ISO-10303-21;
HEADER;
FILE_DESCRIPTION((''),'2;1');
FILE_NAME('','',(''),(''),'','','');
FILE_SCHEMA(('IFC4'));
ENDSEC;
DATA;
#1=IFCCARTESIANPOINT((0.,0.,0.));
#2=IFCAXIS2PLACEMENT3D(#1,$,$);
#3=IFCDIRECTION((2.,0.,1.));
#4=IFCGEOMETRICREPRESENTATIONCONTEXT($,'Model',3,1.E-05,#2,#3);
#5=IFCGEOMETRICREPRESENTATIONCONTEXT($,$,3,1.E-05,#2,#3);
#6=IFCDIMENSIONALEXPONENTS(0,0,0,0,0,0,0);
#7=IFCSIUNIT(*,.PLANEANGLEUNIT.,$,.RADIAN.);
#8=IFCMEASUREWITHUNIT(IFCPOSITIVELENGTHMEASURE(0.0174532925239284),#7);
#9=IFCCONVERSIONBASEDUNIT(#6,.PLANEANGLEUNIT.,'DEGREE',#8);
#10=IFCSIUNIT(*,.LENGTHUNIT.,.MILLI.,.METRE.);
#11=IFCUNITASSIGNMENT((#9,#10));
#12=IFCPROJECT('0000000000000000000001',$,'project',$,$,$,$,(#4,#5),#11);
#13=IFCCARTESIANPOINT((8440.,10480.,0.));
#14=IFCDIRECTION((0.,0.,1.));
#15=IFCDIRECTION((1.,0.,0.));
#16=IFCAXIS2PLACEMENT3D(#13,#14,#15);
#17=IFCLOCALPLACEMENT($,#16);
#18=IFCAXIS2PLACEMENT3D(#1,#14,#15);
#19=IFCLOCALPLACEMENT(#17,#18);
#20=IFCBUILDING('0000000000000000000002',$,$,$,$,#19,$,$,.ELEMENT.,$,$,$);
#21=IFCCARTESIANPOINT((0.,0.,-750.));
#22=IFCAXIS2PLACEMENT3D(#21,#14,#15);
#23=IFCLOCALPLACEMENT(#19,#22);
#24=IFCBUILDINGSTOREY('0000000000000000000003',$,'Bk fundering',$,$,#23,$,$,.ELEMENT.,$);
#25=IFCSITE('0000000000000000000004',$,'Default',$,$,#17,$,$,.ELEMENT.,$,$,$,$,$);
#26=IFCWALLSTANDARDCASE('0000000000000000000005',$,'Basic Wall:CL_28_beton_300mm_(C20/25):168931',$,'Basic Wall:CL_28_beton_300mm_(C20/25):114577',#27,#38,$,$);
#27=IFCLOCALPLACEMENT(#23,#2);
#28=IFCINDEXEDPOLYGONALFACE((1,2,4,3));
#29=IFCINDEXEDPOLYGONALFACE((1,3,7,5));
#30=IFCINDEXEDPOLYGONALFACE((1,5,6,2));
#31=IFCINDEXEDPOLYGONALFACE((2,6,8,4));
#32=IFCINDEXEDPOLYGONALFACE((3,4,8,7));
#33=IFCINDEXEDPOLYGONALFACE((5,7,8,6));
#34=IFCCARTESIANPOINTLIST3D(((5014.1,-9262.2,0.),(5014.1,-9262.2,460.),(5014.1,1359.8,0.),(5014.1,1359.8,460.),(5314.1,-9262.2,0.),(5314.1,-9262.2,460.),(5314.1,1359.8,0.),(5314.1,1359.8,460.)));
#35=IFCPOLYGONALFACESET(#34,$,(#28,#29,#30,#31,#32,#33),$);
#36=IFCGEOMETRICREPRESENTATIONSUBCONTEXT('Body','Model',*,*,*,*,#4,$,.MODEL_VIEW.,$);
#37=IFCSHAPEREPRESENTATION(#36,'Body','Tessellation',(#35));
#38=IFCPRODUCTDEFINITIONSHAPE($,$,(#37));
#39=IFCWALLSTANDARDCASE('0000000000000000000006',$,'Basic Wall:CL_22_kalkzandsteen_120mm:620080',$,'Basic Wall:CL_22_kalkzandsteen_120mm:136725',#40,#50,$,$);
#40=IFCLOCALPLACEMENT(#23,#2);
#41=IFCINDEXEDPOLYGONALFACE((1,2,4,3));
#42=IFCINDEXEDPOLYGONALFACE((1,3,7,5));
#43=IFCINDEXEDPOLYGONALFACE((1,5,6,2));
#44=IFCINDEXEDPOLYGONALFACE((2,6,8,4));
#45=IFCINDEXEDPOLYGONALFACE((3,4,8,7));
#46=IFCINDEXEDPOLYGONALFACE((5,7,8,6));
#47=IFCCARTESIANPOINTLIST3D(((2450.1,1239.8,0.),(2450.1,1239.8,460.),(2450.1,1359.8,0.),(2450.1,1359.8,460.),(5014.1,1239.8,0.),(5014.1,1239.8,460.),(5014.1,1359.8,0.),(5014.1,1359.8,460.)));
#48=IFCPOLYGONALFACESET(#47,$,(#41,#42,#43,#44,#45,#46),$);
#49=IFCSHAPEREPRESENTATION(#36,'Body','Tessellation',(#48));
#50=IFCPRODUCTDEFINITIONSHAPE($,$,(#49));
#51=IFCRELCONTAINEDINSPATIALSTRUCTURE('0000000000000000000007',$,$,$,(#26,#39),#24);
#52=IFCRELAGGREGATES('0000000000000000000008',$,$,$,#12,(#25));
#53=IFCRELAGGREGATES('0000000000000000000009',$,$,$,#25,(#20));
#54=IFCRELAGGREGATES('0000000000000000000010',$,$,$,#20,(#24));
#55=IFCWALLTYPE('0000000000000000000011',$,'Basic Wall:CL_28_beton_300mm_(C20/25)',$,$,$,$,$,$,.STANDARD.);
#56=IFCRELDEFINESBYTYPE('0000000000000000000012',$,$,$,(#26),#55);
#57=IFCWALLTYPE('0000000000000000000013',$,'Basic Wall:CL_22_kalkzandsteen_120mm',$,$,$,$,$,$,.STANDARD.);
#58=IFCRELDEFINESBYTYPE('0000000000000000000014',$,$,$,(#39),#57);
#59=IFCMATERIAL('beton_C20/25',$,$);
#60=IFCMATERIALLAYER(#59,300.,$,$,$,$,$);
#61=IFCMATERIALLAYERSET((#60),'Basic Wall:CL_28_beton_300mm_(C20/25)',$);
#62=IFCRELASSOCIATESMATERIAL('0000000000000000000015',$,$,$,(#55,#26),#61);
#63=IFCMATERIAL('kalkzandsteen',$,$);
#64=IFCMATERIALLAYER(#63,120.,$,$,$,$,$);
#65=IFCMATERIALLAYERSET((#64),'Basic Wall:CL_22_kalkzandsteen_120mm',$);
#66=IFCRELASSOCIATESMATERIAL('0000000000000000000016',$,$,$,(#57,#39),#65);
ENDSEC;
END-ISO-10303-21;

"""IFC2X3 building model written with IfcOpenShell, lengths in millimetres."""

from ifc_helpers import new_model, entity, si_unit, converted_unit, direction, frame, frame_2d, origin, origin_with_axes, place, context, subcontext, project, spatial, rectangle, extrude, material, layer, layer_set, layer_usage, type_object, element, save


model = new_model("IFC2X3")

# Units and contexts
model_context = context("Model", 3, precision=1e-05, world=origin(), true_north=direction((2.0, 0.0, 1.0)))
context_of_model = context(None, 3, precision=1e-05, world=origin(), true_north=direction((2.0, 0.0, 1.0)))
body_context = subcontext(model_context, "Body", "Model", "MODEL_VIEW")
ifc_project = project(units=[converted_unit("PLANEANGLEUNIT", "DEGREE", entity("IfcPositiveLengthMeasure", 0.0174532925239284), si_unit("PLANEANGLEUNIT", "RADIAN"), dimensions=[0, 0, 0, 0, 0, 0, 0]), si_unit("LENGTHUNIT", "METRE", prefix="MILLI")], contexts=[model_context, context_of_model])

# Site, building, storey
site_placement = place(None, frame((8440.0, 10480.0, 0.0), z_axis=(0.0, 0.0, 1.0), x_axis=(1.0, 0.0, 0.0)))
site = spatial("IfcSite", under=ifc_project, at=site_placement, Name="Default", CompositionType="ELEMENT")
building_placement = place(site_placement, origin_with_axes())
building = spatial("IfcBuilding", under=site, at=building_placement, CompositionType="ELEMENT")
storey_placement = place(building_placement, frame((0.0, 0.0, -750.0), z_axis=(0.0, 0.0, 1.0), x_axis=(1.0, 0.0, 0.0)))
storey = spatial("IfcBuildingStorey", under=building, at=storey_placement, Name="Bk fundering", CompositionType="ELEMENT")

# Shared definitions
ifc_material_1 = material(Name="beton_C20/25")

# Shared definitions
ifc_material_2 = material(Name="kalkzandsteen")

# Walls
ifc_layer_1 = layer(ifc_material_1, 300.0)
ifc_layer_set_1 = layer_set([ifc_layer_1], Name="Basic Wall:CL_28_beton_300mm_(C20/25)")
ifc_layer_usage_1 = layer_usage(ifc_layer_set_1, "AXIS2", "NEGATIVE", 150.0)
wall_type_1 = type_object("IfcWallType", Name="Basic Wall:CL_28_beton_300mm_(C20/25)", PredefinedType="STANDARD", material=ifc_layer_set_1)
wall_1_placement = place(storey_placement, frame((5164.1, 1359.8, 0.0), z_axis=(0.0, 0.0, 1.0), x_axis=(0.0, -1.0, 0.0)))
element("IfcWallStandardCase", 1, at=wall_1_placement, inside=storey, type_object=wall_type_1, material=ifc_layer_usage_1, Name="Basic Wall:CL_28_beton_300mm_(C20/25):168931", ObjectType="Basic Wall:CL_28_beton_300mm_(C20/25):114577", context=body_context, shape_type="SweptSolid", body=[
    extrude(rectangle(XDim=10622.0, YDim=300.0, at=frame_2d((5311.0, 0.0), x_axis=(-1.0, 0.0))), origin(), (0.0, 0.0, 1.0), 460.0),
])
ifc_layer_2 = layer(ifc_material_2, 120.0)
ifc_layer_set_2 = layer_set([ifc_layer_2], Name="Basic Wall:CL_22_kalkzandsteen_120mm")
ifc_layer_usage_2 = layer_usage(ifc_layer_set_2, "AXIS2", "NEGATIVE", 60.0)
wall_type_2 = type_object("IfcWallType", Name="Basic Wall:CL_22_kalkzandsteen_120mm", PredefinedType="STANDARD", material=ifc_layer_set_2)
wall_2_placement = place(storey_placement, frame((5014.1, 1299.8, 0.0), z_axis=(0.0, 0.0, 1.0), x_axis=(-1.0, 0.0, 0.0)))
element("IfcWallStandardCase", 2, at=wall_2_placement, inside=storey, type_object=wall_type_2, material=ifc_layer_usage_2, Name="Basic Wall:CL_22_kalkzandsteen_120mm:620080", ObjectType="Basic Wall:CL_22_kalkzandsteen_120mm:136725", context=body_context, shape_type="SweptSolid", body=[
    extrude(rectangle(XDim=2564.0, YDim=120.0, at=frame_2d((1282.0, 0.0), x_axis=(-1.0, 0.0))), origin(), (0.0, 0.0, 1.0), 460.0),
])

save(model, "model.ifc")
